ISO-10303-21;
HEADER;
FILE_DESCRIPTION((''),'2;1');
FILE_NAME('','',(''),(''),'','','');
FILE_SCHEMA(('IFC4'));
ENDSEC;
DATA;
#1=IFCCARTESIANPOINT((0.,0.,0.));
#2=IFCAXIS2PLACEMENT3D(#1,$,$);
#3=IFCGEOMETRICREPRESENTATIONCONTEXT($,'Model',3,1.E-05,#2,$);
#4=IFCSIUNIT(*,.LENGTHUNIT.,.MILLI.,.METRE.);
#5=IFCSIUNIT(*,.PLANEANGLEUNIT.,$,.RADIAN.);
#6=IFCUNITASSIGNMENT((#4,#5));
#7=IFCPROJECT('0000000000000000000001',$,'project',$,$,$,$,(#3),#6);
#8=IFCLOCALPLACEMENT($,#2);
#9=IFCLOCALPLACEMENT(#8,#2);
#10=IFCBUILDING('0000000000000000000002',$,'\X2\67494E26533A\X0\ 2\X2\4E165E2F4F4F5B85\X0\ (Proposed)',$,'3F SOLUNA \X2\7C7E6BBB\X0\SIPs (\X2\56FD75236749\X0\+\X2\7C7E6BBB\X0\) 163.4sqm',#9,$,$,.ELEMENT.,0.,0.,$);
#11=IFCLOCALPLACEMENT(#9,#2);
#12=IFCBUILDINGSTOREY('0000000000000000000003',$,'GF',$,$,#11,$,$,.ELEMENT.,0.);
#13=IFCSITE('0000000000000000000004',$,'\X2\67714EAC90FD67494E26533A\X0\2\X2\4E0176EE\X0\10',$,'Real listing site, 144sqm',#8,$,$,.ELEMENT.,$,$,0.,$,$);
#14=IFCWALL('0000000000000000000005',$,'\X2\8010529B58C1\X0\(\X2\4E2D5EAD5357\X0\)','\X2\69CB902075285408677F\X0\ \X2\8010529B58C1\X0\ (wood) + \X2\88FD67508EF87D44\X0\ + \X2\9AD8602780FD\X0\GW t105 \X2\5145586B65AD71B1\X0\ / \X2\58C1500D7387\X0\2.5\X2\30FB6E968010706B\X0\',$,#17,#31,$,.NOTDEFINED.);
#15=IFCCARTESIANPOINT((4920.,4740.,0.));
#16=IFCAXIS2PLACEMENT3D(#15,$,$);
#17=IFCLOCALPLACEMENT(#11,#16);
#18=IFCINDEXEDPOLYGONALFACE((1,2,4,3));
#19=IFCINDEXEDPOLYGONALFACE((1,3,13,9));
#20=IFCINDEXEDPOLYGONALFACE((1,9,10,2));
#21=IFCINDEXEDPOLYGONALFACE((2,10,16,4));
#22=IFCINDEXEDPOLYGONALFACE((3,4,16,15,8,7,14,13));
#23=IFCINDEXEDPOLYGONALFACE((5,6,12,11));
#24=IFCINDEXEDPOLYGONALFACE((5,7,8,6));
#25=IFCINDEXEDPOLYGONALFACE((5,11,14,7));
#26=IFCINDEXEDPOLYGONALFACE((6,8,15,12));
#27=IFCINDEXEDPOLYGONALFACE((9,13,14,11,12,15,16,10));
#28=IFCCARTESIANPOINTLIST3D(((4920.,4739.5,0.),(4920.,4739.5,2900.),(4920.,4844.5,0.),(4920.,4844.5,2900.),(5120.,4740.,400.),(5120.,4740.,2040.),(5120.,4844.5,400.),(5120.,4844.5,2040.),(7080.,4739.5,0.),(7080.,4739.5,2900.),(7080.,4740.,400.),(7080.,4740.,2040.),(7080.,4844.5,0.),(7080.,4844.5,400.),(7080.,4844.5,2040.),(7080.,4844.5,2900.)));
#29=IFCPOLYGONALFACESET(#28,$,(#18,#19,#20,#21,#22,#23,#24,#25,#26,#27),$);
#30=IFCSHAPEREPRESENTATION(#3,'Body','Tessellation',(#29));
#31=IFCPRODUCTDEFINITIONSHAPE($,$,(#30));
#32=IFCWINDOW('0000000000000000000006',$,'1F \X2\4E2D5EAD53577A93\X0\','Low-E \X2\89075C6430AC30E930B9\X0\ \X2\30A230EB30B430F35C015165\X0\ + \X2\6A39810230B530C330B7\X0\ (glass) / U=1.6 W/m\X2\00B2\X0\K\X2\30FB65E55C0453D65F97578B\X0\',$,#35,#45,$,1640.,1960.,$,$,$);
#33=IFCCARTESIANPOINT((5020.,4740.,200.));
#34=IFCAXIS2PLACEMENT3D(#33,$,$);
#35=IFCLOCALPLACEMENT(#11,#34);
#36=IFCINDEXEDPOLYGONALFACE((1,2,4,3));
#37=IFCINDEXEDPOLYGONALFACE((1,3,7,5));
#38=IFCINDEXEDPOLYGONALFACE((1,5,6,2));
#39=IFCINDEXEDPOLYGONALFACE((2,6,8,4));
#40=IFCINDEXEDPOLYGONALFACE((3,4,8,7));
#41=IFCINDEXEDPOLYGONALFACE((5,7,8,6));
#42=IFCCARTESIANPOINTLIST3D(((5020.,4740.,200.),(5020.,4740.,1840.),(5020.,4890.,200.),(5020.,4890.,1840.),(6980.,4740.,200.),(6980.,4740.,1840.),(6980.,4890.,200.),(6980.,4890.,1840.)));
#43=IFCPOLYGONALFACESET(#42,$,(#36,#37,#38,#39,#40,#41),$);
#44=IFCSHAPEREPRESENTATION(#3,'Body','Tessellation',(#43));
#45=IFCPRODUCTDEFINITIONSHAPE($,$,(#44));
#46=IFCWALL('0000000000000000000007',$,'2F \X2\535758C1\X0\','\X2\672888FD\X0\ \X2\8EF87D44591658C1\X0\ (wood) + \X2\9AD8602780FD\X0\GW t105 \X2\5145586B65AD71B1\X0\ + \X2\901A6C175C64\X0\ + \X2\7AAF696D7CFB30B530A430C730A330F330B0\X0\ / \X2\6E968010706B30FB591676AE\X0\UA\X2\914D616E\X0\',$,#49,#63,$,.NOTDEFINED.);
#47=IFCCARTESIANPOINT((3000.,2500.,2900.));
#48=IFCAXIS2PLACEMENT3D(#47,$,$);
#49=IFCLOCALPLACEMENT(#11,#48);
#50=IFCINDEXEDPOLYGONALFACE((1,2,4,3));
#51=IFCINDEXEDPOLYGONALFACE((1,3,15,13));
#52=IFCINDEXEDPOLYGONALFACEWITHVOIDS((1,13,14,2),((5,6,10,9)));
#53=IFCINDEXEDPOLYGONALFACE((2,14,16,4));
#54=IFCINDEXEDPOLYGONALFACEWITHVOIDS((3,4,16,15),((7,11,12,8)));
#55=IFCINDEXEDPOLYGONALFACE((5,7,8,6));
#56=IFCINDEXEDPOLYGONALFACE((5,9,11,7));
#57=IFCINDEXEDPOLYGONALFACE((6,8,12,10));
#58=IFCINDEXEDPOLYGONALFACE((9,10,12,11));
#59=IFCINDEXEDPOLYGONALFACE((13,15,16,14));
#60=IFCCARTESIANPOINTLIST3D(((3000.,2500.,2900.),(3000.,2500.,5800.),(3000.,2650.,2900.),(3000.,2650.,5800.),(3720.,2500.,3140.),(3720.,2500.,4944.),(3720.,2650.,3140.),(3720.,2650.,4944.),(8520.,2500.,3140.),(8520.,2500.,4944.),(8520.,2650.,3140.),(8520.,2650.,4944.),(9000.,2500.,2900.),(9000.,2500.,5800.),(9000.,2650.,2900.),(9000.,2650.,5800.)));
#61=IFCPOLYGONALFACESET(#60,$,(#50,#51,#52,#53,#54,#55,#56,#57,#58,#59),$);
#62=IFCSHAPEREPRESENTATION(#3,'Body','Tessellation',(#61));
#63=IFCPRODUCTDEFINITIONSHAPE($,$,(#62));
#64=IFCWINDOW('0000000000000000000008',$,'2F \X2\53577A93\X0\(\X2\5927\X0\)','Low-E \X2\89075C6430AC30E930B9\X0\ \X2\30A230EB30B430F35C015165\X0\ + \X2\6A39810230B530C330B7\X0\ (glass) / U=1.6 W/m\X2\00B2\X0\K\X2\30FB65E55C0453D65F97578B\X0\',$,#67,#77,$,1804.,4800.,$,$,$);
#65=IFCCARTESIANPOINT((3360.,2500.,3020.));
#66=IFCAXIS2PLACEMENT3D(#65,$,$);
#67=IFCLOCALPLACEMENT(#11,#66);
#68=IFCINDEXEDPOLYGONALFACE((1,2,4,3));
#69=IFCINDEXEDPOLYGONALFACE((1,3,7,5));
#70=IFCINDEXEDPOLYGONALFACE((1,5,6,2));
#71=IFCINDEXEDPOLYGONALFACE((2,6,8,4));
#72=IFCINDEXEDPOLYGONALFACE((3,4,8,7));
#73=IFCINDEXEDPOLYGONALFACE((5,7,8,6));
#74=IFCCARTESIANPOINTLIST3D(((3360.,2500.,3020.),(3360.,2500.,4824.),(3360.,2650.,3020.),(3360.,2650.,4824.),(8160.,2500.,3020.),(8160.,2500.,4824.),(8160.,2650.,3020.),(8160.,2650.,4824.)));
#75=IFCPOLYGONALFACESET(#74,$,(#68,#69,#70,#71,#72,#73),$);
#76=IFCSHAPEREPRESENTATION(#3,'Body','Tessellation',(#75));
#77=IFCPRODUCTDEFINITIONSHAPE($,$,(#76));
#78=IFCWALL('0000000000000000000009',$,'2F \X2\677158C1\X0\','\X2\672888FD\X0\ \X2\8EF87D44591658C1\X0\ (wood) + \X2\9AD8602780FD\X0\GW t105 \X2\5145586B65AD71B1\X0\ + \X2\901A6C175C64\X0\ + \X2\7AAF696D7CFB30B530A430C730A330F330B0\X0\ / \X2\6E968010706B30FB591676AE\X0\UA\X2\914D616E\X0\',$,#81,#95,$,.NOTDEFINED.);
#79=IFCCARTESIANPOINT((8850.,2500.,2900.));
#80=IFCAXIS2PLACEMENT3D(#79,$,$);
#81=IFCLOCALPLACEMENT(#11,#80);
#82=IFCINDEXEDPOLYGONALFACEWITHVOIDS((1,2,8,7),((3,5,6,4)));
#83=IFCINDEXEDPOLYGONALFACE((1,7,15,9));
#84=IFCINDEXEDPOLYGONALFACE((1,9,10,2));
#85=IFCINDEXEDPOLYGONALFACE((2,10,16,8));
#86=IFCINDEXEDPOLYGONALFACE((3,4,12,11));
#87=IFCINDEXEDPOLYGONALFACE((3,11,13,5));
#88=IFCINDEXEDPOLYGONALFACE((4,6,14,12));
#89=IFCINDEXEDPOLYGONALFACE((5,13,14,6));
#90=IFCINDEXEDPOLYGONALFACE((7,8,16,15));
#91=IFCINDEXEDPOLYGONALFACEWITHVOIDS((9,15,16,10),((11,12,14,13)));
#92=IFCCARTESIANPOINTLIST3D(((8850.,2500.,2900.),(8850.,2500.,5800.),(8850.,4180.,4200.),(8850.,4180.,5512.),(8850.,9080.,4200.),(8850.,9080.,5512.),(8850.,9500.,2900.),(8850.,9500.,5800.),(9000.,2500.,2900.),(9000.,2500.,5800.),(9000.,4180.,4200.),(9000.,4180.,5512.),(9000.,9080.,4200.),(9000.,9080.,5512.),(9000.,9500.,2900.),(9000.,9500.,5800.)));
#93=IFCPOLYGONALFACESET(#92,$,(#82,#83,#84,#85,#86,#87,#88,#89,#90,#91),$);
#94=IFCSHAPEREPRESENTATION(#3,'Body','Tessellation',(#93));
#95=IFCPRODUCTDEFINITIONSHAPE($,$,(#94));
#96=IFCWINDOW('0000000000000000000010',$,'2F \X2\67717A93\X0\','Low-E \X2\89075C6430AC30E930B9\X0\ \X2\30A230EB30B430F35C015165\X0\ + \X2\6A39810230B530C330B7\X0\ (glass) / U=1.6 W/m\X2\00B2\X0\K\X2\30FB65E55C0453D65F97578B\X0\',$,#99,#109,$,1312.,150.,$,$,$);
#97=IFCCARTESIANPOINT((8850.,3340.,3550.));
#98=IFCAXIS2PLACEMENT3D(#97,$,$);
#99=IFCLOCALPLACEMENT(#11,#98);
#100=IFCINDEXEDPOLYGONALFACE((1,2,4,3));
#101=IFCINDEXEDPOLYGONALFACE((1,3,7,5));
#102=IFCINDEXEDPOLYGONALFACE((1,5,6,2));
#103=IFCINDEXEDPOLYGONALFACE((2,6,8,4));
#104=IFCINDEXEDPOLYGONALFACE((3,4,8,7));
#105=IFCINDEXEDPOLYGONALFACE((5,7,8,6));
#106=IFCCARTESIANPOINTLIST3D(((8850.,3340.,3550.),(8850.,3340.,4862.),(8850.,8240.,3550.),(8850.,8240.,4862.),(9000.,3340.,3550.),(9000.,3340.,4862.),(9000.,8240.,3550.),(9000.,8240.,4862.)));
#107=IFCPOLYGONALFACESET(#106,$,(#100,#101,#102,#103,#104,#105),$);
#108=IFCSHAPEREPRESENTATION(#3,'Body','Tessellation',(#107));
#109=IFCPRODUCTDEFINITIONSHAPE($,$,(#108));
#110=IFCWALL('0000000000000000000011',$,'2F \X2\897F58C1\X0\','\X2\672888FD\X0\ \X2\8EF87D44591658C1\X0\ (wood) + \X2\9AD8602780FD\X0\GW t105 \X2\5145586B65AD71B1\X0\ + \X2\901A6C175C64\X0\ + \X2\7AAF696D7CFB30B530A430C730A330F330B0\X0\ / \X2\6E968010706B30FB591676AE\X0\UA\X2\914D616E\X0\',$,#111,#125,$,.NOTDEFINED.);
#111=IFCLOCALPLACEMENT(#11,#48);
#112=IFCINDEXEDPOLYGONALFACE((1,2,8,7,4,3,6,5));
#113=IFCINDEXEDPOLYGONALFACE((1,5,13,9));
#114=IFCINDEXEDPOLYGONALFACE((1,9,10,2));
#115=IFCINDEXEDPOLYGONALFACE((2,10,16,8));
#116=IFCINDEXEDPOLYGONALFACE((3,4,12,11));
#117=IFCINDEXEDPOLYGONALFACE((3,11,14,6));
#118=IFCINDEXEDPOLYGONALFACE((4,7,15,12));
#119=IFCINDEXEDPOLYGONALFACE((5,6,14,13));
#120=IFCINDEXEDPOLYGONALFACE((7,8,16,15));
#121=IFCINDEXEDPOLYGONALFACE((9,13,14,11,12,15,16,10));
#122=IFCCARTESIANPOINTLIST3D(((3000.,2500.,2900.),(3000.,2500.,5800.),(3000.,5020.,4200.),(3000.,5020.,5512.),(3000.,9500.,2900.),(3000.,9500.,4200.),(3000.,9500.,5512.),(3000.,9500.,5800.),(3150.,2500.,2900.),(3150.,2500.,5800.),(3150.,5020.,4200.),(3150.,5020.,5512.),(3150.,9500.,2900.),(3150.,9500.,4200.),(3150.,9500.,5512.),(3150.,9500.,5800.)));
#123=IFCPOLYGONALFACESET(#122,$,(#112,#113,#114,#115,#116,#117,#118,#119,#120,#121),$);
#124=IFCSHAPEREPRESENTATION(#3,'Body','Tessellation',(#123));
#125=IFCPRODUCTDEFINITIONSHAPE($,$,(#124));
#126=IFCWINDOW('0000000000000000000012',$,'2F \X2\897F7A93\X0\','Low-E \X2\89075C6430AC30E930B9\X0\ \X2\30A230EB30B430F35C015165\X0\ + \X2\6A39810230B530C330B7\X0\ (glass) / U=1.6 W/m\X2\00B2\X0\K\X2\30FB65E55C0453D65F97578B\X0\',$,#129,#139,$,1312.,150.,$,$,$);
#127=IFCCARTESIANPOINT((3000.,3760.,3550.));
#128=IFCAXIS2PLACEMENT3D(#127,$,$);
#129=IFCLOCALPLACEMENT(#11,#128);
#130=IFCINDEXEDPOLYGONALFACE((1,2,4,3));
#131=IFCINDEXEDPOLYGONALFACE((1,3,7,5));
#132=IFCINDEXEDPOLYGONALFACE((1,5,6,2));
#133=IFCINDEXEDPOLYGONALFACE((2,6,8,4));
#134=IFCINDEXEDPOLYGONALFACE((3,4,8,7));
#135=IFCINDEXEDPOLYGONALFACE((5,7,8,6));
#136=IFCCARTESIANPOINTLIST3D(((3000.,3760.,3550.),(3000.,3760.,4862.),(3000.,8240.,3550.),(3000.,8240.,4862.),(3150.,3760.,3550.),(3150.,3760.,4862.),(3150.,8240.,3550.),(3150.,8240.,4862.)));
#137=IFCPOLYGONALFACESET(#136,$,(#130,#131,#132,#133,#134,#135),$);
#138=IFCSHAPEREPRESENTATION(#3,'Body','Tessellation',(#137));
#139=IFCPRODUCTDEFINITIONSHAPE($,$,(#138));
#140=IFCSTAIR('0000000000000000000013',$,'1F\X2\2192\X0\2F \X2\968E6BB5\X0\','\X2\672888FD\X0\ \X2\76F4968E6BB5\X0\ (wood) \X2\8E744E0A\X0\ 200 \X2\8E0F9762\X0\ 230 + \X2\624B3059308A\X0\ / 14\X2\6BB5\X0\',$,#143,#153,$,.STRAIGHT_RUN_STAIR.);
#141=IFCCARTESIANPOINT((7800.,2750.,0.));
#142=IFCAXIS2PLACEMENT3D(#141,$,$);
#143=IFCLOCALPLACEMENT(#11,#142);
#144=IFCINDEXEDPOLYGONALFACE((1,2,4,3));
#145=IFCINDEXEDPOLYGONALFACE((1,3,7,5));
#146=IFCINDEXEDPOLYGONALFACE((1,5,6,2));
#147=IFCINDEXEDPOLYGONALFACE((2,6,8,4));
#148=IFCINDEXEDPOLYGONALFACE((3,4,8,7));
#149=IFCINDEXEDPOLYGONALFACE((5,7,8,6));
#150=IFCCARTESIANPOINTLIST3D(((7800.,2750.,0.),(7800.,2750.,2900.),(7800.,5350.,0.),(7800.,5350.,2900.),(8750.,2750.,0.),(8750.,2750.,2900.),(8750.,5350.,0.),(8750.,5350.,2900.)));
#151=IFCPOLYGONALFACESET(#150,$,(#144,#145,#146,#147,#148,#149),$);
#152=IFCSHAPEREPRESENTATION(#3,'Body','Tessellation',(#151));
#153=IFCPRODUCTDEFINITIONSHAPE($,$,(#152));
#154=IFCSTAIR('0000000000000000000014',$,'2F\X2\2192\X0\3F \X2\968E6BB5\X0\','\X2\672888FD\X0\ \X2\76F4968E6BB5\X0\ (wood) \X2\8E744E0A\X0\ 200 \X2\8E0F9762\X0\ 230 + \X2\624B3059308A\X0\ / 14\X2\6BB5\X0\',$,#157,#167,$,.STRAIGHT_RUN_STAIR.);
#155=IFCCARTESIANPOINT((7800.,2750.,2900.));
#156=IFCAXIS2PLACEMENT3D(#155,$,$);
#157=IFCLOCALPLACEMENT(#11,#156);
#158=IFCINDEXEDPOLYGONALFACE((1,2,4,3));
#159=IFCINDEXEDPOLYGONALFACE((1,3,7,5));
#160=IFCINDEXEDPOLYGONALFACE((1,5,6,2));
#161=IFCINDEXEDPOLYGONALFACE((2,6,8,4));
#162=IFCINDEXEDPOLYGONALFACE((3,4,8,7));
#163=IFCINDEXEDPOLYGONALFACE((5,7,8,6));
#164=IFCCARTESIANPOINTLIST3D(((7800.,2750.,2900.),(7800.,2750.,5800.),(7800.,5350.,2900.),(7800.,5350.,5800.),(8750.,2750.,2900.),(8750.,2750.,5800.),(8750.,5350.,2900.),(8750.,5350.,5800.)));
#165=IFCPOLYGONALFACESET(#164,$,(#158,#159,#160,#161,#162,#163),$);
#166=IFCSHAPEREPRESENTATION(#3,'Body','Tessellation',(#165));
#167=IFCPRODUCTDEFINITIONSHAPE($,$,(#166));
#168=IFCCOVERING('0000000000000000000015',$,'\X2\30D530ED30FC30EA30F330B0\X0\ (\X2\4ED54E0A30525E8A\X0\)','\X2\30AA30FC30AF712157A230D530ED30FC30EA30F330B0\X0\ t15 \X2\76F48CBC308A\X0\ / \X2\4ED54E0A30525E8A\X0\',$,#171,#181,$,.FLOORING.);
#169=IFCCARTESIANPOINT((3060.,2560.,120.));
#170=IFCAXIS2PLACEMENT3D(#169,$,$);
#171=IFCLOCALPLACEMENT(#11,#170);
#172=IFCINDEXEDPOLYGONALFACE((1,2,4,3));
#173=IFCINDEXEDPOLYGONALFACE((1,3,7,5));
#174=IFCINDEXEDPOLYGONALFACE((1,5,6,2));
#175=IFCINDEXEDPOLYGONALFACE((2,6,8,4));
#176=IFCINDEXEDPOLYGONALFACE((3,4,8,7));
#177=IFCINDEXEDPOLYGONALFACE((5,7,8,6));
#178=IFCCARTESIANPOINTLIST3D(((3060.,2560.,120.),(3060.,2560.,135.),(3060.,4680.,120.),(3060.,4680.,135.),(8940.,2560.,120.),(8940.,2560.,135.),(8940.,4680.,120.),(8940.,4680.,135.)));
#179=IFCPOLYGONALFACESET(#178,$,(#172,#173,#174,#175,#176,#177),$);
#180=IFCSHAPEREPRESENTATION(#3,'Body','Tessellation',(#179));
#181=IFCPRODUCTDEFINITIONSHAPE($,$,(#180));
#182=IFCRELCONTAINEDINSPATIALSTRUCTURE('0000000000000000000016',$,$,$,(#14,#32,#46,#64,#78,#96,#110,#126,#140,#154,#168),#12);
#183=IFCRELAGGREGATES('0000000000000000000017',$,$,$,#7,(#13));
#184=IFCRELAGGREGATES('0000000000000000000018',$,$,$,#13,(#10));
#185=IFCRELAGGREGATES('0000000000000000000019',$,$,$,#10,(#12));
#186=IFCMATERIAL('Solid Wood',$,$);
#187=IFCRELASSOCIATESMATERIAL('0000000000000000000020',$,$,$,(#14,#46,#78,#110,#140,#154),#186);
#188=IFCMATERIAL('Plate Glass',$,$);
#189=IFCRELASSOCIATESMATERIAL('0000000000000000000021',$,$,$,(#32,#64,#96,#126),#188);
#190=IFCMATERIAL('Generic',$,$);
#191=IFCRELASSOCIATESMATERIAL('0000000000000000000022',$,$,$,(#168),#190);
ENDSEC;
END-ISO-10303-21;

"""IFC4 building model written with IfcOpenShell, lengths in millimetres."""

from ifc_helpers import new_model, si_unit, frame, frame_2d, origin, place, context, project, spatial, rectangle, extrude, material, element, fill, save


model = new_model("IFC4")

# Units and contexts
model_context = context("Model", 3, precision=1e-05, world=origin())
ifc_project = project(units=[si_unit("LENGTHUNIT", "METRE", prefix="MILLI"), si_unit("PLANEANGLEUNIT", "RADIAN")], contexts=[model_context])

# Site, building, storey
site_placement = place(None, origin())
site = spatial("IfcSite", under=ifc_project, at=site_placement, Name="東京都杉並区2丁目10", ObjectType="Real listing site, 144sqm", CompositionType="ELEMENT", RefElevation=0.0)
building_placement = place(site_placement, origin())
building = spatial("IfcBuilding", under=site, at=building_placement, Name="杉並区 2世帯住宅 (Proposed)", ObjectType="3F SOLUNA 籾殻SIPs (国産杉+籾殻) 163.4sqm", CompositionType="ELEMENT", ElevationOfRefHeight=0.0, ElevationOfTerrain=0.0)
storey_placement = place(building_placement, origin())
storey = spatial("IfcBuildingStorey", under=building, at=storey_placement, Name="GF", CompositionType="ELEMENT", Elevation=0.0)

# Shared definitions
ifc_material_1 = material(Name="Solid Wood")
ifc_material_2 = material(Name="Generic")

# Shared definitions
ifc_material_3 = material(Name="Plate Glass")

# Walls, openings, windows
wall_1_placement = place(storey_placement, frame((4920.0, 4740.0, 0.0)))
wall_1 = element("IfcWall", 1, at=wall_1_placement, inside=storey, material=ifc_material_1, Name="耐力壁(中庭南)", Description="構造用合板 耐力壁 (wood) + 製材軸組 + 高性能GW t105 充填断熱 / 壁倍率2.5・準耐火", PredefinedType="NOTDEFINED", context=model_context, shape_type="SweptSolid", body=[
    extrude(rectangle(XDim=2160.0, YDim=105.0, at=frame_2d((1080.0, 52.0))), frame((4920.0, 4740.0, 0.0)), (0.0, 0.0, 1.0), 2900.0),
])
opening_1_placement = place(storey_placement, frame((5020.0, 4740.0, 200.0)))
opening_1 = element("IfcOpeningElement", 2, at=opening_1_placement, cuts=wall_1, PredefinedType="NOTDEFINED", context=model_context, shape_type="SweptSolid", body=[
    extrude(rectangle(XDim=1960.0, YDim=150.0, at=frame_2d((980.0, 75.0))), frame((5020.0, 4740.0, 200.0)), (0.0, 0.0, 1.0), 1640.0),
])
window_1_placement = place(storey_placement, frame((5020.0, 4740.0, 200.0)))
window_1 = element("IfcWindow", 3, at=window_1_placement, inside=storey, material=ifc_material_3, Name="1F 中庭南窓", Description="Low-E 複層ガラス アルゴン封入 + 樹脂サッシ (glass) / U=1.6 W/m²K・日射取得型", OverallHeight=1640.0, OverallWidth=1960.0, context=model_context, shape_type="SweptSolid", body=[
    extrude(rectangle(XDim=1960.0, YDim=150.0, at=frame_2d((980.0, 75.0))), frame((5020.0, 4740.0, 200.0)), (0.0, 0.0, 1.0), 1640.0),
])
fill(opening_1, window_1)
wall_2_placement = place(storey_placement, frame((3000.0, 2500.0, 2900.0)))
wall_2 = element("IfcWall", 4, at=wall_2_placement, inside=storey, material=ifc_material_1, Name="2F 南壁", Description="木製 軸組外壁 (wood) + 高性能GW t105 充填断熱 + 通気層 + 窯業系サイディング / 準耐火・外皮UA配慮", PredefinedType="NOTDEFINED", context=model_context, shape_type="SweptSolid", body=[
    extrude(rectangle(XDim=6000.0, YDim=150.0, at=frame_2d((3000.0, 75.0))), frame((3000.0, 2500.0, 2900.0)), (0.0, 0.0, 1.0), 2900.0),
])
opening_2_placement = place(storey_placement, frame((3360.0, 2500.0, 3020.0)))
opening_2 = element("IfcOpeningElement", 5, at=opening_2_placement, cuts=wall_2, PredefinedType="NOTDEFINED", context=model_context, shape_type="SweptSolid", body=[
    extrude(rectangle(XDim=4800.0, YDim=150.0, at=frame_2d((2400.0, 75.0))), frame((3360.0, 2500.0, 3020.0)), (0.0, 0.0, 1.0), 1804.0),
])
window_2_placement = place(storey_placement, frame((3360.0, 2500.0, 3020.0)))
window_2 = element("IfcWindow", 6, at=window_2_placement, inside=storey, material=ifc_material_3, Name="2F 南窓(大)", Description="Low-E 複層ガラス アルゴン封入 + 樹脂サッシ (glass) / U=1.6 W/m²K・日射取得型", OverallHeight=1804.0, OverallWidth=4800.0, context=model_context, shape_type="SweptSolid", body=[
    extrude(rectangle(XDim=4800.0, YDim=150.0, at=frame_2d((2400.0, 75.0))), frame((3360.0, 2500.0, 3020.0)), (0.0, 0.0, 1.0), 1804.0),
])
fill(opening_2, window_2)
wall_3_placement = place(storey_placement, frame((8850.0, 2500.0, 2900.0)))
wall_3 = element("IfcWall", 7, at=wall_3_placement, inside=storey, material=ifc_material_1, Name="2F 東壁", Description="木製 軸組外壁 (wood) + 高性能GW t105 充填断熱 + 通気層 + 窯業系サイディング / 準耐火・外皮UA配慮", PredefinedType="NOTDEFINED", context=model_context, shape_type="SweptSolid", body=[
    extrude(rectangle(XDim=150.0, YDim=7000.0, at=frame_2d((75.0, 3500.0))), frame((8850.0, 2500.0, 2900.0)), (0.0, 0.0, 1.0), 2900.0),
])
opening_3_placement = place(storey_placement, frame((8850.0, 3340.0, 3550.0)))
opening_3 = element("IfcOpeningElement", 8, at=opening_3_placement, cuts=wall_3, PredefinedType="NOTDEFINED", context=model_context, shape_type="SweptSolid", body=[
    extrude(rectangle(XDim=150.0, YDim=4900.0, at=frame_2d((75.0, 2450.0))), frame((8850.0, 3340.0, 3550.0)), (0.0, 0.0, 1.0), 1312.0),
])
window_3_placement = place(storey_placement, frame((8850.0, 3340.0, 3550.0)))
window_3 = element("IfcWindow", 9, at=window_3_placement, inside=storey, material=ifc_material_3, Name="2F 東窓", Description="Low-E 複層ガラス アルゴン封入 + 樹脂サッシ (glass) / U=1.6 W/m²K・日射取得型", OverallHeight=1312.0, OverallWidth=150.0, context=model_context, shape_type="SweptSolid", body=[
    extrude(rectangle(XDim=150.0, YDim=4900.0, at=frame_2d((75.0, 2450.0))), frame((8850.0, 3340.0, 3550.0)), (0.0, 0.0, 1.0), 1312.0),
])
fill(opening_3, window_3)
wall_4_placement = place(storey_placement, frame((3000.0, 2500.0, 2900.0)))
wall_4 = element("IfcWall", 10, at=wall_4_placement, inside=storey, material=ifc_material_1, Name="2F 西壁", Description="木製 軸組外壁 (wood) + 高性能GW t105 充填断熱 + 通気層 + 窯業系サイディング / 準耐火・外皮UA配慮", PredefinedType="NOTDEFINED", context=model_context, shape_type="SweptSolid", body=[
    extrude(rectangle(XDim=150.0, YDim=7000.0, at=frame_2d((75.0, 3500.0))), frame((3000.0, 2500.0, 2900.0)), (0.0, 0.0, 1.0), 2900.0),
])
opening_4_placement = place(storey_placement, frame((3000.0, 3760.0, 3550.0)))
opening_4 = element("IfcOpeningElement", 11, at=opening_4_placement, cuts=wall_4, PredefinedType="NOTDEFINED", context=model_context, shape_type="SweptSolid", body=[
    extrude(rectangle(XDim=150.0, YDim=4480.0, at=frame_2d((75.0, 2240.0))), frame((3000.0, 3760.0, 3550.0)), (0.0, 0.0, 1.0), 1312.0),
])
window_4_placement = place(storey_placement, frame((3000.0, 3760.0, 3550.0)))
window_4 = element("IfcWindow", 12, at=window_4_placement, inside=storey, material=ifc_material_3, Name="2F 西窓", Description="Low-E 複層ガラス アルゴン封入 + 樹脂サッシ (glass) / U=1.6 W/m²K・日射取得型", OverallHeight=1312.0, OverallWidth=150.0, context=model_context, shape_type="SweptSolid", body=[
    extrude(rectangle(XDim=150.0, YDim=4480.0, at=frame_2d((75.0, 2240.0))), frame((3000.0, 3760.0, 3550.0)), (0.0, 0.0, 1.0), 1312.0),
])
fill(opening_4, window_4)

# Stairs
stair_1_placement = place(storey_placement, frame((7800.0, 2750.0, 0.0)))
element("IfcStair", 13, at=stair_1_placement, inside=storey, material=ifc_material_1, Name="1F→2F 階段", Description="木製 直階段 (wood) 蹴上 200 踏面 230 + 手すり / 14段", PredefinedType="STRAIGHT_RUN_STAIR", context=model_context, shape_type="SweptSolid", body=[
    extrude(rectangle(XDim=950.0, YDim=2600.0, at=frame_2d((475.0, 1300.0))), frame((7800.0, 2750.0, 0.0)), (0.0, 0.0, 1.0), 2900.0),
])
stair_2_placement = place(storey_placement, frame((7800.0, 2750.0, 2900.0)))
element("IfcStair", 14, at=stair_2_placement, inside=storey, material=ifc_material_1, Name="2F→3F 階段", Description="木製 直階段 (wood) 蹴上 200 踏面 230 + 手すり / 14段", PredefinedType="STRAIGHT_RUN_STAIR", context=model_context, shape_type="SweptSolid", body=[
    extrude(rectangle(XDim=950.0, YDim=2600.0, at=frame_2d((475.0, 1300.0))), frame((7800.0, 2750.0, 2900.0)), (0.0, 0.0, 1.0), 2900.0),
])

# Covering
covering_placement = place(storey_placement, frame((3060.0, 2560.0, 120.0)))
element("IfcCovering", 15, at=covering_placement, inside=storey, material=ifc_material_2, Name="フローリング (仕上げ床)", Description="オーク無垢フローリング t15 直貼り / 仕上げ床", PredefinedType="FLOORING", context=model_context, shape_type="SweptSolid", body=[
    extrude(rectangle(XDim=5880.0, YDim=2120.0, at=frame_2d((2940.0, 1060.0))), frame((3060.0, 2560.0, 120.0)), (0.0, 0.0, 1.0), 15.0),
])

save(model, "model.ifc")
